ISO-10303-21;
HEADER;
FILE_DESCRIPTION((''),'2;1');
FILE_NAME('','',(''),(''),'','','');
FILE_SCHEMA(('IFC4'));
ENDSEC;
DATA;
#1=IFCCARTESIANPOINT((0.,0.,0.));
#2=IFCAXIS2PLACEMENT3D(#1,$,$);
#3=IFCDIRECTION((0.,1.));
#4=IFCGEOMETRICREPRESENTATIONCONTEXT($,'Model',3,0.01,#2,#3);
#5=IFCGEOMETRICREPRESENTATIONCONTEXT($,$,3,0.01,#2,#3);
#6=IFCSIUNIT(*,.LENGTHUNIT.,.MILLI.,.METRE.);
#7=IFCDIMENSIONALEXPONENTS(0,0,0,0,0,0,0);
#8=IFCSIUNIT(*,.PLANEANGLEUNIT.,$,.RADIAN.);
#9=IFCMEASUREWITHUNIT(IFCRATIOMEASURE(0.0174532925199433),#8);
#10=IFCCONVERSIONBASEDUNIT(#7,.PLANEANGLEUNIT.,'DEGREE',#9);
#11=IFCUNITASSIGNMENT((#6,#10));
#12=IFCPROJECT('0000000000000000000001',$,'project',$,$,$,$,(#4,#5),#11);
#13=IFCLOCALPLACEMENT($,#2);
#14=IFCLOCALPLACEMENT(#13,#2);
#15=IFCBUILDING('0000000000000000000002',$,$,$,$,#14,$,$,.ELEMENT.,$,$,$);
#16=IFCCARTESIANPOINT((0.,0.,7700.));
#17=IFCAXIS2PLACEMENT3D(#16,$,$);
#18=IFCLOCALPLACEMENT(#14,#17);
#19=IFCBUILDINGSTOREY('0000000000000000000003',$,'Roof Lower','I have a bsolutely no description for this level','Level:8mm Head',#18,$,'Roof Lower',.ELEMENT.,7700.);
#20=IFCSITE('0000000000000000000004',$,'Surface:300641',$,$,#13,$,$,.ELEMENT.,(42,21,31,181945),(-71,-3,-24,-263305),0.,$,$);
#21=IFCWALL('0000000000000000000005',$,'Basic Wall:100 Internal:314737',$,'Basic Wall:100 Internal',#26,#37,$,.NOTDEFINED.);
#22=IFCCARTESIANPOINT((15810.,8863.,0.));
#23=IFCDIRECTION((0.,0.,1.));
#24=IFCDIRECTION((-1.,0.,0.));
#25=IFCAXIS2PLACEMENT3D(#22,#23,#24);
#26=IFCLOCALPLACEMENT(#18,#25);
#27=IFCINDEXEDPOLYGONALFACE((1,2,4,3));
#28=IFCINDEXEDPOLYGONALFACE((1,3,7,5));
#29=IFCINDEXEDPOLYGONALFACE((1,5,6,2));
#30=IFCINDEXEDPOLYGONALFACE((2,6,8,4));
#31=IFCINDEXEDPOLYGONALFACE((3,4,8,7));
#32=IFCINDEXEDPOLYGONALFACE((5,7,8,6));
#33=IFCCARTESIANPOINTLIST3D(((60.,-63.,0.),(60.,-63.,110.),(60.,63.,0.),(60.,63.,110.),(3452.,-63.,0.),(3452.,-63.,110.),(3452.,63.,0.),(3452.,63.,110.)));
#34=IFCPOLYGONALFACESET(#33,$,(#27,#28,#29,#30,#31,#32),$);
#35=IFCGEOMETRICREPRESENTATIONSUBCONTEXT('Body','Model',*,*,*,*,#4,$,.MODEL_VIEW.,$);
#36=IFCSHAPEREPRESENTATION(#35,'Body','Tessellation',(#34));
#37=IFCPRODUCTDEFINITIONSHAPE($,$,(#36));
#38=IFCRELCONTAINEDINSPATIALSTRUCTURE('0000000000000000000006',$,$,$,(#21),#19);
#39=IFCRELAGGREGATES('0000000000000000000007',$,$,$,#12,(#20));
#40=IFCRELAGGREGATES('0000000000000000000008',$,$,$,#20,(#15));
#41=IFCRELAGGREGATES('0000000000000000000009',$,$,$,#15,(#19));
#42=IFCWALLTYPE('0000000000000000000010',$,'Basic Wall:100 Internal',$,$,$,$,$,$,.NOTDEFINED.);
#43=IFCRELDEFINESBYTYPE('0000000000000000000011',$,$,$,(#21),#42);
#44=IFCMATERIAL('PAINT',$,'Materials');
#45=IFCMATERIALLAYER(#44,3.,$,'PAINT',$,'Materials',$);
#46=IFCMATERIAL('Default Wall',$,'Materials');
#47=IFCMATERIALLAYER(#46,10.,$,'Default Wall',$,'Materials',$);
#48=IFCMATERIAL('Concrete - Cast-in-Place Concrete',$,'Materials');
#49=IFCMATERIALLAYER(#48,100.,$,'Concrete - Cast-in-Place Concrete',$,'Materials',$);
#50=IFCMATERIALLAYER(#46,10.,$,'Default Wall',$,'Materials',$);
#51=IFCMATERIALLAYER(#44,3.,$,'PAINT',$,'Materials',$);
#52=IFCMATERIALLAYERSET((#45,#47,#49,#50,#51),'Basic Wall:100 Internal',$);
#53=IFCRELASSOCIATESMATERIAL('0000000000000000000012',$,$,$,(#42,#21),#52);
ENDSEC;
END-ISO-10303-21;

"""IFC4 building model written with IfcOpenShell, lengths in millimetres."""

from ifc_helpers import new_model, entity, si_unit, converted_unit, direction, frame, frame_2d, origin, place, context, subcontext, project, spatial, polyline, rectangle, extrude, clip, halfspace, bounded_halfspace, material, layer, layer_set, layer_usage, type_object, element, save


model = new_model("IFC4")

# Units and contexts
model_context = context("Model", 3, precision=0.01, world=origin(), true_north=direction((0.0, 1.0)))
context_of_model = context(None, 3, precision=0.01, world=origin(), true_north=direction((0.0, 1.0)))
body_context = subcontext(model_context, "Body", "Model", "MODEL_VIEW")
ifc_project = project(units=[si_unit("LENGTHUNIT", "METRE", prefix="MILLI"), converted_unit("PLANEANGLEUNIT", "DEGREE", entity("IfcRatioMeasure", 0.0174532925199433), si_unit("PLANEANGLEUNIT", "RADIAN"), dimensions=[0, 0, 0, 0, 0, 0, 0])], contexts=[model_context, context_of_model])

# Site, building, storey
site_placement = place(None, origin())
site = spatial("IfcSite", under=ifc_project, at=site_placement, Name="Surface:300641", CompositionType="ELEMENT", RefLatitude=(42, 21, 31, 181945), RefLongitude=(-71, -3, -24, -263305), RefElevation=0.0)
building_placement = place(site_placement, origin())
building = spatial("IfcBuilding", under=site, at=building_placement, CompositionType="ELEMENT")
storey_placement = place(building_placement, frame((0.0, 0.0, 7700.0)))
storey = spatial("IfcBuildingStorey", under=building, at=storey_placement, Name="Roof Lower", Description="I have a bsolutely no description for this level", ObjectType="Level:8mm Head", LongName="Roof Lower", CompositionType="ELEMENT", Elevation=7700.0)

# Shared definitions
ifc_material_1 = material(Name="Concrete - Cast-in-Place Concrete", Category="Materials")

# Wall
ifc_material_2 = material(Name="PAINT", Category="Materials")
ifc_material_3 = material(Name="Default Wall", Category="Materials")
ifc_layer_1 = layer(ifc_material_2, 3.0, Name="PAINT", Category="Materials")
ifc_layer_2 = layer(ifc_material_3, 10.0, Name="Default Wall", Category="Materials")
ifc_layer_3 = layer(ifc_material_1, 100.0, Name="Concrete - Cast-in-Place Concrete", Category="Materials")
ifc_layer_4 = layer(ifc_material_3, 10.0, Name="Default Wall", Category="Materials")
ifc_layer_5 = layer(ifc_material_2, 3.0, Name="PAINT", Category="Materials")
ifc_layer_set_1 = layer_set([ifc_layer_1, ifc_layer_2, ifc_layer_3, ifc_layer_4, ifc_layer_5], Name="Basic Wall:100 Internal")
wall_type_1 = type_object("IfcWallType", Name="Basic Wall:100 Internal", PredefinedType="NOTDEFINED", material=ifc_layer_set_1)
ifc_layer_usage_1 = layer_usage(ifc_layer_set_1, "AXIS2", "NEGATIVE", 63.0)
wall_1_placement = place(storey_placement, frame((15810.0, 8863.0, 0.0), z_axis=(0.0, 0.0, 1.0), x_axis=(-1.0, 0.0, 0.0)))
element("IfcWall", 1, at=wall_1_placement, inside=storey, type_object=wall_type_1, material=ifc_layer_usage_1, Name="Basic Wall:100 Internal:314737", ObjectType="Basic Wall:100 Internal", PredefinedType="NOTDEFINED", context=body_context, shape_type="Clipping", body=[
    clip(clip(extrude(rectangle(XDim=3392.0, YDim=126.0, at=frame_2d((1756.0, 0.0), x_axis=(-1.0, 0.0))), origin(), (0.0, 0.0, 1.0), 110.0), bounded_halfspace(frame((0.0, -63.0, 110.0), z_axis=(0.0, 0.0, -1.0), x_axis=(-1.0, 0.0, 0.0)), True, frame((0.0, -63.0, 110.0)), polyline([(0.0, 0.0), (3361.6, 0.0), (3452.0, 0.0), (3452.0, 126.0), (60.0, 126.0), (0.0, 126.0), (0.0, 0.0)]))), halfspace(frame((0.0, 0.0, -3500.0)), True)),
])

save(model, "model.ifc")
